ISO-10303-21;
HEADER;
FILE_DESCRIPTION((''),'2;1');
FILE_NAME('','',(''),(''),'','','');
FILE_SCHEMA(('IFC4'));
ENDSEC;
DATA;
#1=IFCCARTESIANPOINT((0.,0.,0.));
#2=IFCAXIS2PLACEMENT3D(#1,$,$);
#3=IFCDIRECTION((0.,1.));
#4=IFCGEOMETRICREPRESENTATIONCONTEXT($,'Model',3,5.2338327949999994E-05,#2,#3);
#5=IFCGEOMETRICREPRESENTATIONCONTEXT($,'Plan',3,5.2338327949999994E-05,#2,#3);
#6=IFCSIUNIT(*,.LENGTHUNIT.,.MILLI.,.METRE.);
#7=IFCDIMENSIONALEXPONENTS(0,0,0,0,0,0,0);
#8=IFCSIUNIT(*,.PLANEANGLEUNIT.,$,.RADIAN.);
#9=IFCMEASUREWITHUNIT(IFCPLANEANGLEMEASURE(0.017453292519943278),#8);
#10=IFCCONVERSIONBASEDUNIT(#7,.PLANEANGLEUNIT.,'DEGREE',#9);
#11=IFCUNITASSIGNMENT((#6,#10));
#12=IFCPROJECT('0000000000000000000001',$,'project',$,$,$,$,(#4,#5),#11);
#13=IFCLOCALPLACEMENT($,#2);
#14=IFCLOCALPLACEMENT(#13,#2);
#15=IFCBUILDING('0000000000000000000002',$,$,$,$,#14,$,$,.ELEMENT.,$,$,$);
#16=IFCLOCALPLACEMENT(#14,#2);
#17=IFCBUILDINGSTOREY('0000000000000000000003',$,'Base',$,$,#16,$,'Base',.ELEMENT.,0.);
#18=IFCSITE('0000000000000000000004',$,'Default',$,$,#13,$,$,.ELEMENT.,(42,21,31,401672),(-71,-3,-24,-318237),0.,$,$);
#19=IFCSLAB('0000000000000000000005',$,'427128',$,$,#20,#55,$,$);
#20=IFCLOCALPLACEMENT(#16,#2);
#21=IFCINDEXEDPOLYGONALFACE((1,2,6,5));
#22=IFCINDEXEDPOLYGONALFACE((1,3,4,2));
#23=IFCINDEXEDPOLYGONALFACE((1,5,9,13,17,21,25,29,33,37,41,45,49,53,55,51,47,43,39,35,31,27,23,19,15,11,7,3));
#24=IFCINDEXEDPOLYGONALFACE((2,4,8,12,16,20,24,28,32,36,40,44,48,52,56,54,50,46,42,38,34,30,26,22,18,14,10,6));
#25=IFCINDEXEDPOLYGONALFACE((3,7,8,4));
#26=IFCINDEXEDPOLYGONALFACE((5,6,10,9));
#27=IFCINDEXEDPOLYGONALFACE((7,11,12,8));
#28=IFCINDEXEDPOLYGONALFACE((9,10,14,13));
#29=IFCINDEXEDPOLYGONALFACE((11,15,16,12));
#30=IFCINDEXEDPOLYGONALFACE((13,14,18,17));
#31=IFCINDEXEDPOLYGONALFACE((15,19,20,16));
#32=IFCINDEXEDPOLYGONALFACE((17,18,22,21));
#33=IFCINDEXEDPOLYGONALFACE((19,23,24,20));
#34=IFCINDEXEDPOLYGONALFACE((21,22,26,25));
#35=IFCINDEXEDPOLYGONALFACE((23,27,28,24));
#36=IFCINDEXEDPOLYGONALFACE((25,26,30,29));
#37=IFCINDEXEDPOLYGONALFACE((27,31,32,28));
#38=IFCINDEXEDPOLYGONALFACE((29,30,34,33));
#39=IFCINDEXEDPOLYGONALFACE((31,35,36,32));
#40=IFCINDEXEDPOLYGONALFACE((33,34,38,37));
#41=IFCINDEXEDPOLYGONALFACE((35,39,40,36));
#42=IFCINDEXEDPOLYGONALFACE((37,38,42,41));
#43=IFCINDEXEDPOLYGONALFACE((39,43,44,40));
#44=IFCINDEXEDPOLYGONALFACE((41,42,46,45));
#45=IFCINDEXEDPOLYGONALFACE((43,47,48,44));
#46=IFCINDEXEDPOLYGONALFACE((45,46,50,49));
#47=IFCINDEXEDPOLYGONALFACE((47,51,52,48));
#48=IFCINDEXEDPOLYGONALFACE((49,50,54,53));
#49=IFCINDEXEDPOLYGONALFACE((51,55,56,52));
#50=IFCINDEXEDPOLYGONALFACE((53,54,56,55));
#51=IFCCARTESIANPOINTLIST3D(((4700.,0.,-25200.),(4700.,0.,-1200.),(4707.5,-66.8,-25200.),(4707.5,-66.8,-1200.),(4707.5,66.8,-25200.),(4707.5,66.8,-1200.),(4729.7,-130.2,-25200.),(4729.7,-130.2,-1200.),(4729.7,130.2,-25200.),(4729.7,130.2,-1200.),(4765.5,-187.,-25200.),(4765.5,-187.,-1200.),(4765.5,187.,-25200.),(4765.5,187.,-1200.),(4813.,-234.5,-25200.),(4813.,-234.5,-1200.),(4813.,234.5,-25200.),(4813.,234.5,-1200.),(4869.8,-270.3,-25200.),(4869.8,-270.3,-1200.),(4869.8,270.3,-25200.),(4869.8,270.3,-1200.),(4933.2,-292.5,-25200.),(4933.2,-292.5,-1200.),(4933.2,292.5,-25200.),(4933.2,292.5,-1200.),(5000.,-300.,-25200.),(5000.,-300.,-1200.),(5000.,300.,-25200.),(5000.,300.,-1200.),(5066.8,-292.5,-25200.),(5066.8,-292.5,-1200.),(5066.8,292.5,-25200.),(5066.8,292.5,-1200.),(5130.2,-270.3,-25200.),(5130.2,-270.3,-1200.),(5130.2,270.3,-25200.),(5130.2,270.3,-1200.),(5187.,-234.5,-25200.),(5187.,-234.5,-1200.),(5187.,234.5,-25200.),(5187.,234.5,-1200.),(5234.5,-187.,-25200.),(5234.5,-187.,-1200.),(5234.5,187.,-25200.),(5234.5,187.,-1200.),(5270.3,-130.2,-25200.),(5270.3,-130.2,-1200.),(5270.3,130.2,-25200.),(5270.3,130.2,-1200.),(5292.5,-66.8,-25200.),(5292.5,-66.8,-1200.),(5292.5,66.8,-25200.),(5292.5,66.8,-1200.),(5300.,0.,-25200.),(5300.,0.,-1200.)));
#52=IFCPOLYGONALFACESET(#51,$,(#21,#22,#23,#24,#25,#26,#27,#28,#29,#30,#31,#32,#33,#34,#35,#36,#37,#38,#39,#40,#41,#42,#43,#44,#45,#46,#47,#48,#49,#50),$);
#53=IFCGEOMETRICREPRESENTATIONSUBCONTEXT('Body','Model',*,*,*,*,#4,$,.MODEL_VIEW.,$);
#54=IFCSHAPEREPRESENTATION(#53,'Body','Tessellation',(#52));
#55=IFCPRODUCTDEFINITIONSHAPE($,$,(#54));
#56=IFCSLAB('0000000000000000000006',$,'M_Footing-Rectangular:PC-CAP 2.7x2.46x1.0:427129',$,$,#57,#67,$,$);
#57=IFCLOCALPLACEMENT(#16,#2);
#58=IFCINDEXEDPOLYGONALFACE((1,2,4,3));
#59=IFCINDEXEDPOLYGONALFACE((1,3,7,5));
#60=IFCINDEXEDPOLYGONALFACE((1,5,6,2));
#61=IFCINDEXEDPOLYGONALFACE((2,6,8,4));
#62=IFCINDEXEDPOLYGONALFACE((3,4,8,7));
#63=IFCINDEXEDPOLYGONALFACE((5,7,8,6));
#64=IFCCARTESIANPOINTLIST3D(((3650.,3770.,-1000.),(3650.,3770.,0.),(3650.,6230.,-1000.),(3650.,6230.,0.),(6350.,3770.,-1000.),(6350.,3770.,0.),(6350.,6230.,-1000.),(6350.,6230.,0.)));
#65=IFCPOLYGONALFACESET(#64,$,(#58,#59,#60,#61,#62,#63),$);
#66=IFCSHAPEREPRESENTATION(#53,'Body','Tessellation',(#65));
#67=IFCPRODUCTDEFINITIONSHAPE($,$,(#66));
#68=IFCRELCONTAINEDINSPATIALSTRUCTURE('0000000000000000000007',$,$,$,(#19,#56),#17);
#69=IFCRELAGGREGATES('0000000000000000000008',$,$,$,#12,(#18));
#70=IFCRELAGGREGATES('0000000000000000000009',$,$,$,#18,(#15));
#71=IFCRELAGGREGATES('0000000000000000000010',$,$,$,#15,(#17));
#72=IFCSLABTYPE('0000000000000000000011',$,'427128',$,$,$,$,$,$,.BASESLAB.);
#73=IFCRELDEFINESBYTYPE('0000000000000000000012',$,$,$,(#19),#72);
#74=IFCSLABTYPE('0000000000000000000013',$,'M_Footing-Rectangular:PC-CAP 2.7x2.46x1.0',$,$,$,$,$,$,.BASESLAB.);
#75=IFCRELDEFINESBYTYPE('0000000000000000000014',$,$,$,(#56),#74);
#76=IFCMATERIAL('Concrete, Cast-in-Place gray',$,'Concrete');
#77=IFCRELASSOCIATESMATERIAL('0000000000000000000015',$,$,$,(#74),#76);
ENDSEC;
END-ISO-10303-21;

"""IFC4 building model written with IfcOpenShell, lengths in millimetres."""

from ifc_helpers import new_model, entity, si_unit, converted_unit, direction, frame, origin, place, context, subcontext, project, spatial, arc, indexed_curve, outline, extrude, material, type_object, element, save


model = new_model("IFC4")

# Units and contexts
model_context = context("Model", 3, precision=5.2338327949999994e-05, world=origin(), true_north=direction((0.0, 1.0)))
plan_context = context("Plan", 3, precision=5.2338327949999994e-05, world=origin(), true_north=direction((0.0, 1.0)))
body_context = subcontext(model_context, "Body", "Model", "MODEL_VIEW")
ifc_project = project(units=[si_unit("LENGTHUNIT", "METRE", prefix="MILLI"), converted_unit("PLANEANGLEUNIT", "DEGREE", entity("IfcPlaneAngleMeasure", 0.017453292519943278), si_unit("PLANEANGLEUNIT", "RADIAN"), dimensions=[0, 0, 0, 0, 0, 0, 0])], contexts=[model_context, plan_context])

# Site, building, storey
site_placement = place(None, origin())
site = spatial("IfcSite", under=ifc_project, at=site_placement, Name="Default", CompositionType="ELEMENT", RefLatitude=(42, 21, 31, 401672), RefLongitude=(-71, -3, -24, -318237), RefElevation=0.0)
building_placement = place(site_placement, origin())
building = spatial("IfcBuilding", under=site, at=building_placement, CompositionType="ELEMENT")
storey_placement = place(building_placement, origin())
storey = spatial("IfcBuildingStorey", under=building, at=storey_placement, Name="Base", LongName="Base", CompositionType="ELEMENT", Elevation=0.0)

# Slabs
ifc_material_1 = material(Name="Concrete, Cast-in-Place gray", Category="Concrete")
slab_type_1 = type_object("IfcSlabType", Name="427128", PredefinedType="BASESLAB")
slab_1_placement = place(storey_placement, origin())
element("IfcSlab", 1, at=slab_1_placement, inside=storey, type_object=slab_type_1, Name="427128", context=body_context, shape_type="SweptSolid", body=[
    extrude(outline(indexed_curve([(300.0, 0.0), (0.0, 300.0), (-300.0, 0.0), (0.0, -300.0)], segments=[arc(1, 2, 3), arc(3, 4, 1)], self_intersect=False)), frame((5000.0, 0.0, -25200.0)), (0.0, 0.0, 1.0), 24000.0),
])
slab_type_2 = type_object("IfcSlabType", Name="M_Footing-Rectangular:PC-CAP 2.7x2.46x1.0", PredefinedType="BASESLAB", material=ifc_material_1)
slab_2_placement = place(storey_placement, origin())
element("IfcSlab", 2, at=slab_2_placement, inside=storey, type_object=slab_type_2, Name="M_Footing-Rectangular:PC-CAP 2.7x2.46x1.0:427129", context=body_context, shape_type="SweptSolid", body=[
    extrude(outline(indexed_curve([(-1350.0, -1230.0), (1350.0, -1230.0), (1350.0, 1230.0), (-1350.0, 1230.0), (-1350.0, -1230.0)], self_intersect=False)), frame((5000.0, 5000.0, -1000.0), z_axis=(0.0, 0.0, 1.0), x_axis=(-1.0, 0.0, 0.0)), (0.0, 0.0, 1.0), 1000.0),
])

save(model, "model.ifc")
